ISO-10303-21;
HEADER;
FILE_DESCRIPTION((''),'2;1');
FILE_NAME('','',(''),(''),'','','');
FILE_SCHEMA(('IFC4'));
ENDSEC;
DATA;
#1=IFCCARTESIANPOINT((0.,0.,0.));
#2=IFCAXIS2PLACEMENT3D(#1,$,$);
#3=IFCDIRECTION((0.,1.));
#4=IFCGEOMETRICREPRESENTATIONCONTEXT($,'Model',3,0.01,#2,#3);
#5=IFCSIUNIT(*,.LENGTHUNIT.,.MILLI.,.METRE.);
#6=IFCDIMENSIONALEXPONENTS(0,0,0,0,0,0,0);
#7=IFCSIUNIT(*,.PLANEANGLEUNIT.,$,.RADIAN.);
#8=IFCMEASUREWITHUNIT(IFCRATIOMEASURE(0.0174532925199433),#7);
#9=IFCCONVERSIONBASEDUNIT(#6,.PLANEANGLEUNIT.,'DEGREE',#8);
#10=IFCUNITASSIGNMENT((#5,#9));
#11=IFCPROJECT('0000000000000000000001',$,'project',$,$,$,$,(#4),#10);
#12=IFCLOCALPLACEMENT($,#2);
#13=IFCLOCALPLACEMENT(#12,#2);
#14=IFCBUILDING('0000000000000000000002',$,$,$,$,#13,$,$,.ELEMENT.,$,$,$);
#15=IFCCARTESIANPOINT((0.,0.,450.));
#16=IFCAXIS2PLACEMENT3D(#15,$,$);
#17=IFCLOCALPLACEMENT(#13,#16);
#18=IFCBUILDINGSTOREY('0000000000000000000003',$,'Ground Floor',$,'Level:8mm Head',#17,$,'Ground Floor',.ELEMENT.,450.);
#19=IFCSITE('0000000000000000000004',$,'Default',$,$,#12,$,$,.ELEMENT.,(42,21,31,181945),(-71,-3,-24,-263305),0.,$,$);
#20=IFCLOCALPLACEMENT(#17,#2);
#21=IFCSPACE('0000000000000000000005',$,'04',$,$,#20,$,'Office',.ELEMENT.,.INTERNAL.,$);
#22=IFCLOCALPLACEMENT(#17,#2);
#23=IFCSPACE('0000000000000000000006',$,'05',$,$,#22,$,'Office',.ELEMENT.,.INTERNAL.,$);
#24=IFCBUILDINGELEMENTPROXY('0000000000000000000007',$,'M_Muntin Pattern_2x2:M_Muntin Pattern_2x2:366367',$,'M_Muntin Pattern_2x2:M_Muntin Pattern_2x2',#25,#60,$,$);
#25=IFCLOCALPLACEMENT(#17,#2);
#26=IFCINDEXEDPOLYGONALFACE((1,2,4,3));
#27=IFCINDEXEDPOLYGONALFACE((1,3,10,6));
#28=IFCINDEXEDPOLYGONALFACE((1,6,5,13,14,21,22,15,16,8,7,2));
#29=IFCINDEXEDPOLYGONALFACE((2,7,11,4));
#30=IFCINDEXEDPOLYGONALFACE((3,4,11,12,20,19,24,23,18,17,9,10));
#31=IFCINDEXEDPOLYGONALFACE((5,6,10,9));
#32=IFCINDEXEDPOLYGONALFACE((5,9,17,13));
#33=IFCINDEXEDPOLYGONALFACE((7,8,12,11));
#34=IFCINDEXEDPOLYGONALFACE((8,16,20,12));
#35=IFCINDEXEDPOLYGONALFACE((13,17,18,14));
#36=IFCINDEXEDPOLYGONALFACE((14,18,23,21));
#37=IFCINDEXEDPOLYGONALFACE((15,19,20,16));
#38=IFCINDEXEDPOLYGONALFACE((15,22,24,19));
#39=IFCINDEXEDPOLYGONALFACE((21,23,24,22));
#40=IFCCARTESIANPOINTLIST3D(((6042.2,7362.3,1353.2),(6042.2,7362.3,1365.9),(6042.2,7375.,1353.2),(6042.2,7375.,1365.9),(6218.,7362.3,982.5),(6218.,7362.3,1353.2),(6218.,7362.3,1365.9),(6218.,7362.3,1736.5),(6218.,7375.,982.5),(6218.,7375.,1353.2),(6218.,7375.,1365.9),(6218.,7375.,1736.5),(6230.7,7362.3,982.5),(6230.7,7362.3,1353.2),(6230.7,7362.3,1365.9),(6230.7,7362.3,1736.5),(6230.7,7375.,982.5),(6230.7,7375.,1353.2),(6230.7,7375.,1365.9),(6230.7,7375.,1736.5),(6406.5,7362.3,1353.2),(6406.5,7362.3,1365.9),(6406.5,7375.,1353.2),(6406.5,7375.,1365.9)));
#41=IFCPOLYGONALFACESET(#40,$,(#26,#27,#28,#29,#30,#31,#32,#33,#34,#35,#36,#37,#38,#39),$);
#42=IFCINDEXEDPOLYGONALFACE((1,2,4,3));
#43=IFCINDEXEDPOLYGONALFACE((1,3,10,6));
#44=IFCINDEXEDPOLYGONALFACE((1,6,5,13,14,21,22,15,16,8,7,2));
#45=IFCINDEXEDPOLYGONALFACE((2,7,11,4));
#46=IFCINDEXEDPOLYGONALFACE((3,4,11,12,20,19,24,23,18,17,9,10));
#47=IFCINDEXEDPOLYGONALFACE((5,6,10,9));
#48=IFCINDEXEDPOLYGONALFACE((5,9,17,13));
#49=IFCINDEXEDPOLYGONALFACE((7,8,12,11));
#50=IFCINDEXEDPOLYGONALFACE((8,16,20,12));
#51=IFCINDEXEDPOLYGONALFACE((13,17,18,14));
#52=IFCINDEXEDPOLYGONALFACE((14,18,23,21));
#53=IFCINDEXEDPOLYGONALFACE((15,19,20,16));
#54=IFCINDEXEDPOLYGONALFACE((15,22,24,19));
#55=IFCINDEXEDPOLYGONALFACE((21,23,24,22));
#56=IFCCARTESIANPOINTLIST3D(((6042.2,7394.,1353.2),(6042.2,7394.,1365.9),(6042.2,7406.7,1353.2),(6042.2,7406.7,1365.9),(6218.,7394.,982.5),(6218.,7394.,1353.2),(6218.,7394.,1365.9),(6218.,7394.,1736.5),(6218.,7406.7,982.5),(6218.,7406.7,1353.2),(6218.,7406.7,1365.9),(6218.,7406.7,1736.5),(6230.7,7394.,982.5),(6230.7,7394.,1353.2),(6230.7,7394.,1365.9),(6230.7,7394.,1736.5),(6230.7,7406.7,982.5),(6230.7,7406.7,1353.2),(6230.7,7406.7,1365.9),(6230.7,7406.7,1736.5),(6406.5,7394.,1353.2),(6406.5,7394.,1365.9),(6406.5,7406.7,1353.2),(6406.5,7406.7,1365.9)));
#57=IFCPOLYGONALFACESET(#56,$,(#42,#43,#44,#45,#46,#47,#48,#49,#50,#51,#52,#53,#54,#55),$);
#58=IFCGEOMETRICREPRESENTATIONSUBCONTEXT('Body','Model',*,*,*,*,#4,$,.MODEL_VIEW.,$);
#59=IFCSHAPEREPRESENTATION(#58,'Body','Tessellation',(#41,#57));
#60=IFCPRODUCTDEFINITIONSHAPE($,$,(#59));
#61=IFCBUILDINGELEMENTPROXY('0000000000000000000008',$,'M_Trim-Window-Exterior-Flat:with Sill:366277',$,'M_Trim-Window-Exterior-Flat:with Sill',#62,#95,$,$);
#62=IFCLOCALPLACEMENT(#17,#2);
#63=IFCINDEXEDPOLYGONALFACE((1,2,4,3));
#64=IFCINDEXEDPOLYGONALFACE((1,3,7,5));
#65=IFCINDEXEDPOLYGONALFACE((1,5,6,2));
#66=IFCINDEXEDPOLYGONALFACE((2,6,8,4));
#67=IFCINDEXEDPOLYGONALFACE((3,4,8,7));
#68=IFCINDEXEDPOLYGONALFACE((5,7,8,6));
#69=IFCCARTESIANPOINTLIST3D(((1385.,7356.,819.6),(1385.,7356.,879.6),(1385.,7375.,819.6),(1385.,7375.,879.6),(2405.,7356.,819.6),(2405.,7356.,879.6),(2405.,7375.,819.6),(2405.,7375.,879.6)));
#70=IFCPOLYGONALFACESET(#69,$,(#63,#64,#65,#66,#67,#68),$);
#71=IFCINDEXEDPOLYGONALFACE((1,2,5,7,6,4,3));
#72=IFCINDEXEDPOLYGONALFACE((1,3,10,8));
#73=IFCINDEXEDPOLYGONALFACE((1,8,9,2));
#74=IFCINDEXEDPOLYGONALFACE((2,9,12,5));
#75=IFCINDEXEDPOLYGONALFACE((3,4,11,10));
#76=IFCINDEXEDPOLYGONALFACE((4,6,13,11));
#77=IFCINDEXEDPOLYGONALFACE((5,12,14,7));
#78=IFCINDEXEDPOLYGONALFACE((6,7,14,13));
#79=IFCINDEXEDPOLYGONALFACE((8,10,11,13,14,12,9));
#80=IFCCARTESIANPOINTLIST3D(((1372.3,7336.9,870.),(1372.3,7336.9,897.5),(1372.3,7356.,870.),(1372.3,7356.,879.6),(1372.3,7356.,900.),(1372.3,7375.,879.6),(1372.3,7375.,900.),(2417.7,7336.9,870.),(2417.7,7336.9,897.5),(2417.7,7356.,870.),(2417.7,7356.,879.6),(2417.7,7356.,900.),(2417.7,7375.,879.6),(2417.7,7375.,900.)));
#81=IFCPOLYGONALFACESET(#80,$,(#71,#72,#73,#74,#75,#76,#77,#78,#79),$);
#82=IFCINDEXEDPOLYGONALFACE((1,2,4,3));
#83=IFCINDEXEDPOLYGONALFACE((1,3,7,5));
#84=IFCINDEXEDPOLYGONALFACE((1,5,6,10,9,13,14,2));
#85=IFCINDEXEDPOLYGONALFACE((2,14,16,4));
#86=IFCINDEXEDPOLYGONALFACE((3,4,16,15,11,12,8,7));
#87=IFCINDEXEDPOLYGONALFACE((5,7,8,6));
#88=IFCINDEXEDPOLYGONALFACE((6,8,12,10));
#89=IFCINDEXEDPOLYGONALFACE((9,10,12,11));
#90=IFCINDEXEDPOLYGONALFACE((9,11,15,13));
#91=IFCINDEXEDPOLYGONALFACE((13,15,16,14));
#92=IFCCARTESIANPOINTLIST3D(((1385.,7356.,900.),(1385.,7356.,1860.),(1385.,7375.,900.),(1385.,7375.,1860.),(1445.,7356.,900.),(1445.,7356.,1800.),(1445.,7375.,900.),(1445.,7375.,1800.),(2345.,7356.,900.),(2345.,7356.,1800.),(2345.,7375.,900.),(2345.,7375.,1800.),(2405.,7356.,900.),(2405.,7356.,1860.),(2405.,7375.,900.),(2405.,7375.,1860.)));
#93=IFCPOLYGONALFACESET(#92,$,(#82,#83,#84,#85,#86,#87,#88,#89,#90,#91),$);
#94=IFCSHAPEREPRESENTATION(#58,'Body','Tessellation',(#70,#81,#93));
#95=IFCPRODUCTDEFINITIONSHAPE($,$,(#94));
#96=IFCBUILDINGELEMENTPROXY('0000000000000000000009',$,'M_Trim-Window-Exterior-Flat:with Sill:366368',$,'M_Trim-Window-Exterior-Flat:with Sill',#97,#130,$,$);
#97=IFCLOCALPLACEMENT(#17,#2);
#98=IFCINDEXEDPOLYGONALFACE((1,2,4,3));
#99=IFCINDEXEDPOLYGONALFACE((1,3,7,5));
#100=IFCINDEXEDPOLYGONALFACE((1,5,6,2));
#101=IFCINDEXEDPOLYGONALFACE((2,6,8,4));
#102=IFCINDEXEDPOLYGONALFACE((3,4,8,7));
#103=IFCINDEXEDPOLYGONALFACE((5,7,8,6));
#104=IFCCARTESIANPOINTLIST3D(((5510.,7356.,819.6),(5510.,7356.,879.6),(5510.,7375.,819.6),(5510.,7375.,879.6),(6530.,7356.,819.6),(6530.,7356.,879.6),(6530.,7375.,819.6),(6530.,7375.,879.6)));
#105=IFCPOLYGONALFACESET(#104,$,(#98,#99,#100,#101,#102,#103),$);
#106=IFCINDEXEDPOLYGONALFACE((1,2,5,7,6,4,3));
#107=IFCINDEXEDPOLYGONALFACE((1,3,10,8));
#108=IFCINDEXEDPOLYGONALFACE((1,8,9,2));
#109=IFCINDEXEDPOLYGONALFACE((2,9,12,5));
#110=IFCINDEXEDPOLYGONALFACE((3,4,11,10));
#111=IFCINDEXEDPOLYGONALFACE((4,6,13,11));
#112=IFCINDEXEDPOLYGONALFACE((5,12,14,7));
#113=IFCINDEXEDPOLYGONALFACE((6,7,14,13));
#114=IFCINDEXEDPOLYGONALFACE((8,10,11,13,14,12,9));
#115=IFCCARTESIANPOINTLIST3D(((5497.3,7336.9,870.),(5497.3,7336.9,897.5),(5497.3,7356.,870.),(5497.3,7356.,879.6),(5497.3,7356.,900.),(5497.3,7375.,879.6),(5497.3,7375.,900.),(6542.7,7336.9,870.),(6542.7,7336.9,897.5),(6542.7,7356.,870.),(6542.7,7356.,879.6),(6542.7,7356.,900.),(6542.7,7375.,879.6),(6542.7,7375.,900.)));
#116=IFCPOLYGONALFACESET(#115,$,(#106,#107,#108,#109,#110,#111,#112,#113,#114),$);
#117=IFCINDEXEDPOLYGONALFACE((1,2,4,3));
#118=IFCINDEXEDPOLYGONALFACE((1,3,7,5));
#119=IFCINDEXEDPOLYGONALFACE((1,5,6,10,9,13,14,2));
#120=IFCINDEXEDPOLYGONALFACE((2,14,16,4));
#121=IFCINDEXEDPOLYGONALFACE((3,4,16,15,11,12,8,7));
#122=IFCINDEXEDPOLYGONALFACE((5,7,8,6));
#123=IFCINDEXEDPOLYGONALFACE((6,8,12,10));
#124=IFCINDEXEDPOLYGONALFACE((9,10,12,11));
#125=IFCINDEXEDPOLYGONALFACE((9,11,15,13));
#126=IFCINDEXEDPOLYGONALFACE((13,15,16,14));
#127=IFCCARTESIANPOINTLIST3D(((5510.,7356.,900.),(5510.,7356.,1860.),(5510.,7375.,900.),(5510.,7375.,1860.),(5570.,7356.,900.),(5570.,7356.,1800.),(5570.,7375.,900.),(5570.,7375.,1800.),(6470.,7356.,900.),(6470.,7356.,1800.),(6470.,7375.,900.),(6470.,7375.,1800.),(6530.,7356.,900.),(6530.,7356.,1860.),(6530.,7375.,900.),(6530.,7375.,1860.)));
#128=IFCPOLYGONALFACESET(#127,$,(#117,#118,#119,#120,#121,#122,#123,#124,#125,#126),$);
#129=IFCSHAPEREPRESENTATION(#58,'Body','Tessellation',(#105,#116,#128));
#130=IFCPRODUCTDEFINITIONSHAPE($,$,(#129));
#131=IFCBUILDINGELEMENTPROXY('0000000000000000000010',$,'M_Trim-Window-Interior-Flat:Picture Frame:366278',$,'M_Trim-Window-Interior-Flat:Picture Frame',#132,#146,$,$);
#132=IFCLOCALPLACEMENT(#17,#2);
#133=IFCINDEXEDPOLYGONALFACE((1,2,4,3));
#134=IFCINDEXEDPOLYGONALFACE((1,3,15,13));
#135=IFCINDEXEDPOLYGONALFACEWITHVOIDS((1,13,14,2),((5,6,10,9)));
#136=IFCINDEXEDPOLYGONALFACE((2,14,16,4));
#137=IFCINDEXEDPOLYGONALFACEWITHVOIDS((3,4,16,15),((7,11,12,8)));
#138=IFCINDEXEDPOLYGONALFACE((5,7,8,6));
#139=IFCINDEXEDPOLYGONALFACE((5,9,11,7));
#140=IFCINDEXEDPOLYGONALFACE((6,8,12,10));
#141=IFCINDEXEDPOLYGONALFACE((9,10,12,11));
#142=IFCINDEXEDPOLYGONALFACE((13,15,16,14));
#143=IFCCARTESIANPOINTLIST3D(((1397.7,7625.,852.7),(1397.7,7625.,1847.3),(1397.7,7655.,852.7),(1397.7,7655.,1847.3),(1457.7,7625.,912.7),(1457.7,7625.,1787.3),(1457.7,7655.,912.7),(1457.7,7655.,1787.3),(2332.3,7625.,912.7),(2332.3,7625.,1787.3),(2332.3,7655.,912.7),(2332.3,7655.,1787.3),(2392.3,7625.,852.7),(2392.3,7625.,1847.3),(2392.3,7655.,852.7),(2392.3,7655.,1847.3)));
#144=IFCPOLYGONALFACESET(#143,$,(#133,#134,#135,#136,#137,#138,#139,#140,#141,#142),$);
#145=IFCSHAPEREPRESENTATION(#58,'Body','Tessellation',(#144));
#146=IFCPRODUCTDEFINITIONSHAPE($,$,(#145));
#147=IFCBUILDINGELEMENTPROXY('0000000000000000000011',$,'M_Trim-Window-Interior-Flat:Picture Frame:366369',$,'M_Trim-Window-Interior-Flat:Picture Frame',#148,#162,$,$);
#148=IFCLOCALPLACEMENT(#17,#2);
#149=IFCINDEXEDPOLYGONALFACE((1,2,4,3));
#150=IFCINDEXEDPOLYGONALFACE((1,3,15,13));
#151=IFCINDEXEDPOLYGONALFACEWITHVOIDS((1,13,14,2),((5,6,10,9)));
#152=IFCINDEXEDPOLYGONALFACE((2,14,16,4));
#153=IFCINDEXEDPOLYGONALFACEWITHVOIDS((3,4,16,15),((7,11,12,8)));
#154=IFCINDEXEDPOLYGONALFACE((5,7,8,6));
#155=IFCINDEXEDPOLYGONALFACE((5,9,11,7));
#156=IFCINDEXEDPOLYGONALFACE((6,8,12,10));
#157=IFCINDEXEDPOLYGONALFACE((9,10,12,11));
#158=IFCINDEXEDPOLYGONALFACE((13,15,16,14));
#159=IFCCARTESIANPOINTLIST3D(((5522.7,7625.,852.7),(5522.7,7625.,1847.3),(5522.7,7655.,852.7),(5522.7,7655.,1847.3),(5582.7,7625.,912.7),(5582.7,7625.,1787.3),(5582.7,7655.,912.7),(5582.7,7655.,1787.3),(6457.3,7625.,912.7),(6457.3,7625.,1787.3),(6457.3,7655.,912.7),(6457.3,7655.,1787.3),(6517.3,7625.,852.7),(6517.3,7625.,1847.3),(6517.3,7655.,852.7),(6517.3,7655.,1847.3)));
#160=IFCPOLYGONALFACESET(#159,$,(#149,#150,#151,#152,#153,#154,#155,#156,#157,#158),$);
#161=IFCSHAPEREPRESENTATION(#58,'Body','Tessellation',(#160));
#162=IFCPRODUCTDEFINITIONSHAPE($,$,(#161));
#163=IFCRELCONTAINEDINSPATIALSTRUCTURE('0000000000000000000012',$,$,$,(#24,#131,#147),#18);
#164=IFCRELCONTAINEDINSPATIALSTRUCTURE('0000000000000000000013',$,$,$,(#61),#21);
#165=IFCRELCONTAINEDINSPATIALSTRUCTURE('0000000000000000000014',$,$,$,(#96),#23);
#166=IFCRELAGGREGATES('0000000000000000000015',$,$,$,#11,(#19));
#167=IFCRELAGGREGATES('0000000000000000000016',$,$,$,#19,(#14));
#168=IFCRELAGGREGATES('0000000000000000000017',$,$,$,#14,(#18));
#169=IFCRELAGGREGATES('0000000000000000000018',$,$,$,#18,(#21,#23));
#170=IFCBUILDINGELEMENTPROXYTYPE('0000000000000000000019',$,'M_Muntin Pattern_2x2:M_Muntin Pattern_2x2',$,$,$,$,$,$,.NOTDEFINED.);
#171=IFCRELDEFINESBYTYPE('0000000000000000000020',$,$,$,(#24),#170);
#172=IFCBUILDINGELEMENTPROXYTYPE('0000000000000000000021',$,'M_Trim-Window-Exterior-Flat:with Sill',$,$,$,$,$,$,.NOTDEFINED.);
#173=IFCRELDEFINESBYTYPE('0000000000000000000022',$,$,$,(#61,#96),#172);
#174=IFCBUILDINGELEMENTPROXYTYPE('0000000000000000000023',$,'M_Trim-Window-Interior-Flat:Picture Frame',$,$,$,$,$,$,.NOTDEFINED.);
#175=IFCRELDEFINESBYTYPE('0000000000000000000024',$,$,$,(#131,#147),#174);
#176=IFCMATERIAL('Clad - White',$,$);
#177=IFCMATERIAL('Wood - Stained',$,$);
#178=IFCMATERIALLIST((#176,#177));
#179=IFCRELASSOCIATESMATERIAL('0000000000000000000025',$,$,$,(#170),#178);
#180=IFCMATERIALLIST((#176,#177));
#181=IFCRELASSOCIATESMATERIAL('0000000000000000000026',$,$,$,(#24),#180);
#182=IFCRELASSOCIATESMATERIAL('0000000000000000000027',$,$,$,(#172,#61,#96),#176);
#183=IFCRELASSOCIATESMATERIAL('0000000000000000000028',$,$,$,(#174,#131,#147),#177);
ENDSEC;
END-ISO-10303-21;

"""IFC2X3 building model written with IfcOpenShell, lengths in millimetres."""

from ifc_helpers import new_model, entity, si_unit, converted_unit, direction, frame, frame_2d, origin, place, context, subcontext, project, spatial, polyline, rectangle, outline, extrude, source, transform, mapped, material, material_list, type_object, type_shapes, element, save


model = new_model("IFC2X3")

# Units and contexts
model_context = context("Model", 3, precision=0.01, world=origin(), true_north=direction((0.0, 1.0)))
body_context = subcontext(model_context, "Body", "Model", "MODEL_VIEW")
ifc_project = project(units=[si_unit("LENGTHUNIT", "METRE", prefix="MILLI"), converted_unit("PLANEANGLEUNIT", "DEGREE", entity("IfcRatioMeasure", 0.0174532925199433), si_unit("PLANEANGLEUNIT", "RADIAN"), dimensions=[0, 0, 0, 0, 0, 0, 0])], contexts=[model_context])

# Site, building, storey
site_placement = place(None, origin())
site = spatial("IfcSite", under=ifc_project, at=site_placement, Name="Default", CompositionType="ELEMENT", RefLatitude=(42, 21, 31, 181945), RefLongitude=(-71, -3, -24, -263305), RefElevation=0.0)
building_placement = place(site_placement, origin())
building = spatial("IfcBuilding", under=site, at=building_placement, CompositionType="ELEMENT")
storey_placement = place(building_placement, frame((0.0, 0.0, 450.0)))
storey = spatial("IfcBuildingStorey", under=building, at=storey_placement, Name="Ground Floor", ObjectType="Level:8mm Head", LongName="Ground Floor", CompositionType="ELEMENT", Elevation=450.0)

# Shared definitions
space_1_placement = place(storey_placement, origin())
space_1 = spatial("IfcSpace", under=storey, at=space_1_placement, Name="04", LongName="Office", CompositionType="ELEMENT", InteriorOrExteriorSpace="INTERNAL")

# Building element proxies
ifc_material_1 = material(Name="Clad - White")
ifc_material_2 = material(Name="Wood - Stained")
ifc_material_list_1 = material_list([ifc_material_1, ifc_material_2])
building_element_proxy_type_1 = type_object("IfcBuildingElementProxyType", Name="M_Muntin Pattern_2x2:M_Muntin Pattern_2x2", PredefinedType="NOTDEFINED", material=ifc_material_list_1)
shared_shape_1 = source(origin(), body_context, "Body", "SweptSolid", [
    extrude(outline(polyline([(6.4, -6.4), (377.0, -6.4), (377.0, 6.3), (6.4, 6.3), (6.4, 182.1), (-6.3, 182.1), (-6.3, 6.3), (-377.0, 6.3), (-377.0, -6.4), (-6.3, -6.4), (-6.3, -182.1), (6.4, -182.1), (6.4, -6.4)])), frame((0.0, 9.5, 377.0), z_axis=(0.0, 1.0, 0.0), x_axis=(0.0, 0.0, 1.0)), (0.0, 0.0, 1.0), 12.7),
    extrude(outline(polyline([(6.4, -6.4), (377.0, -6.4), (377.0, 6.3), (6.4, 6.3), (6.4, 182.1), (-6.3, 182.1), (-6.3, 6.3), (-377.0, 6.3), (-377.0, -6.4), (-6.3, -6.4), (-6.3, -182.1), (6.4, -182.1), (6.4, -6.4)])), frame((0.0, -22.2, 377.0), z_axis=(0.0, 1.0, 0.0), x_axis=(0.0, 0.0, 1.0)), (0.0, 0.0, 1.0), 12.7),
])
type_shapes(building_element_proxy_type_1, [shared_shape_1])
ifc_material_list_2 = material_list([ifc_material_1, ifc_material_2])
proxy_1_placement = place(storey_placement, frame((6224.4, 7384.5, 982.5), z_axis=(0.0, 0.0, 1.0), x_axis=(-1.0, 0.0, 0.0)))
element("IfcBuildingElementProxy", 1, at=proxy_1_placement, inside=storey, type_object=building_element_proxy_type_1, material=ifc_material_list_2, Name="M_Muntin Pattern_2x2:M_Muntin Pattern_2x2:366367", ObjectType="M_Muntin Pattern_2x2:M_Muntin Pattern_2x2", context=body_context, shape_type="MappedRepresentation", body=[
    mapped(shared_shape_1, transform((0.0, 0.0, 0.0), scale=1.0)),
])
building_element_proxy_type_2 = type_object("IfcBuildingElementProxyType", Name="M_Trim-Window-Exterior-Flat:with Sill", PredefinedType="NOTDEFINED", material=ifc_material_1)
shared_shape_2 = source(origin(), body_context, "Body", "SweptSolid", [
    extrude(rectangle(XDim=1020.0, YDim=60.0, at=frame_2d((0.0, 0.0), x_axis=(1.0, 0.0))), frame((0.0, -950.4, 0.0), z_axis=(0.0, 0.0, 1.0), x_axis=(-1.0, 0.0, 0.0)), (0.0, 0.0, 1.0), 19.1),
    extrude(outline(polyline([(-19.0, -15.2), (0.0, -15.2), (0.0, -5.7), (19.0, -5.7), (19.0, 14.8), (0.0, 14.8), (-19.0, 12.3), (-19.0, -15.2)])), frame((-522.7, -914.8, 19.0), z_axis=(1.0, 0.0, 0.0), x_axis=(0.0, 0.0, -1.0)), (0.0, 0.0, 1.0), 1045.4),
    extrude(outline(polyline([(-495.0, -510.0), (465.0, -510.0), (465.0, -450.0), (-435.0, -450.0), (-435.0, 450.0), (465.0, 450.0), (465.0, 510.0), (-495.0, 510.0), (-495.0, -510.0)])), frame((0.0, -435.0, 0.0), z_axis=(0.0, 0.0, 1.0), x_axis=(0.0, -1.0, 0.0)), (0.0, 0.0, 1.0), 19.1),
])
type_shapes(building_element_proxy_type_2, [shared_shape_2])
proxy_2_placement = place(space_1_placement, frame((1895.0, 7375.0, 1800.0), z_axis=(0.0, -1.0, 0.0), x_axis=(1.0, 0.0, 0.0)))
element("IfcBuildingElementProxy", 2, at=proxy_2_placement, inside=space_1, type_object=building_element_proxy_type_2, material=ifc_material_1, Name="M_Trim-Window-Exterior-Flat:with Sill:366277", ObjectType="M_Trim-Window-Exterior-Flat:with Sill", context=body_context, shape_type="MappedRepresentation", body=[
    mapped(shared_shape_2, transform((0.0, 0.0, 0.0), scale=1.0)),
])

# Shared definitions
space_2_placement = place(storey_placement, origin())
space_2 = spatial("IfcSpace", under=storey, at=space_2_placement, Name="05", LongName="Office", CompositionType="ELEMENT", InteriorOrExteriorSpace="INTERNAL")

# Building element proxies
proxy_3_placement = place(space_2_placement, frame((6020.0, 7375.0, 1800.0), z_axis=(0.0, -1.0, 0.0), x_axis=(1.0, 0.0, 0.0)))
element("IfcBuildingElementProxy", 3, at=proxy_3_placement, inside=space_2, type_object=building_element_proxy_type_2, material=ifc_material_1, Name="M_Trim-Window-Exterior-Flat:with Sill:366368", ObjectType="M_Trim-Window-Exterior-Flat:with Sill", context=body_context, shape_type="MappedRepresentation", body=[
    mapped(shared_shape_2, transform((0.0, 0.0, 0.0), scale=1.0)),
])
building_element_proxy_type_3 = type_object("IfcBuildingElementProxyType", Name="M_Trim-Window-Interior-Flat:Picture Frame", PredefinedType="NOTDEFINED", material=ifc_material_2)
shared_shape_3 = source(origin(), body_context, "Body", "SweptSolid", [
    extrude(outline(polyline([(-497.3, -497.3), (497.3, -497.3), (497.3, 497.3), (-497.3, 497.3), (-497.3, -497.3)]), holes=[polyline([(-437.3, -437.3), (-437.3, 437.3), (437.3, 437.3), (437.3, -437.3), (-437.3, -437.3)])]), frame((0.0, -450.0, 0.0), z_axis=(0.0, 0.0, 1.0), x_axis=(-1.0, 0.0, 0.0)), (0.0, 0.0, 1.0), 30.0),
])
type_shapes(building_element_proxy_type_3, [shared_shape_3])
for number, where, z_axis, x_axis, name in (
    (4, (1895.0, 7625.0, 1800.0), (0.0, 1.0, 0.0), (-1.0, 0.0, 0.0), "M_Trim-Window-Interior-Flat:Picture Frame:366278"),
    (5, (6020.0, 7625.0, 1800.0), (0.0, 1.0, 0.0), (-1.0, 0.0, 0.0), "M_Trim-Window-Interior-Flat:Picture Frame:366369"),
):
    element("IfcBuildingElementProxy", number, at=place(storey_placement, frame(where, z_axis=z_axis, x_axis=x_axis)), inside=storey, type_object=building_element_proxy_type_3, material=ifc_material_2, Name=name, ObjectType="M_Trim-Window-Interior-Flat:Picture Frame", context=body_context, shape_type="MappedRepresentation", body=[
        mapped(shared_shape_3, transform((0.0, 0.0, 0.0), scale=1.0)),
    ])

save(model, "model.ifc")
